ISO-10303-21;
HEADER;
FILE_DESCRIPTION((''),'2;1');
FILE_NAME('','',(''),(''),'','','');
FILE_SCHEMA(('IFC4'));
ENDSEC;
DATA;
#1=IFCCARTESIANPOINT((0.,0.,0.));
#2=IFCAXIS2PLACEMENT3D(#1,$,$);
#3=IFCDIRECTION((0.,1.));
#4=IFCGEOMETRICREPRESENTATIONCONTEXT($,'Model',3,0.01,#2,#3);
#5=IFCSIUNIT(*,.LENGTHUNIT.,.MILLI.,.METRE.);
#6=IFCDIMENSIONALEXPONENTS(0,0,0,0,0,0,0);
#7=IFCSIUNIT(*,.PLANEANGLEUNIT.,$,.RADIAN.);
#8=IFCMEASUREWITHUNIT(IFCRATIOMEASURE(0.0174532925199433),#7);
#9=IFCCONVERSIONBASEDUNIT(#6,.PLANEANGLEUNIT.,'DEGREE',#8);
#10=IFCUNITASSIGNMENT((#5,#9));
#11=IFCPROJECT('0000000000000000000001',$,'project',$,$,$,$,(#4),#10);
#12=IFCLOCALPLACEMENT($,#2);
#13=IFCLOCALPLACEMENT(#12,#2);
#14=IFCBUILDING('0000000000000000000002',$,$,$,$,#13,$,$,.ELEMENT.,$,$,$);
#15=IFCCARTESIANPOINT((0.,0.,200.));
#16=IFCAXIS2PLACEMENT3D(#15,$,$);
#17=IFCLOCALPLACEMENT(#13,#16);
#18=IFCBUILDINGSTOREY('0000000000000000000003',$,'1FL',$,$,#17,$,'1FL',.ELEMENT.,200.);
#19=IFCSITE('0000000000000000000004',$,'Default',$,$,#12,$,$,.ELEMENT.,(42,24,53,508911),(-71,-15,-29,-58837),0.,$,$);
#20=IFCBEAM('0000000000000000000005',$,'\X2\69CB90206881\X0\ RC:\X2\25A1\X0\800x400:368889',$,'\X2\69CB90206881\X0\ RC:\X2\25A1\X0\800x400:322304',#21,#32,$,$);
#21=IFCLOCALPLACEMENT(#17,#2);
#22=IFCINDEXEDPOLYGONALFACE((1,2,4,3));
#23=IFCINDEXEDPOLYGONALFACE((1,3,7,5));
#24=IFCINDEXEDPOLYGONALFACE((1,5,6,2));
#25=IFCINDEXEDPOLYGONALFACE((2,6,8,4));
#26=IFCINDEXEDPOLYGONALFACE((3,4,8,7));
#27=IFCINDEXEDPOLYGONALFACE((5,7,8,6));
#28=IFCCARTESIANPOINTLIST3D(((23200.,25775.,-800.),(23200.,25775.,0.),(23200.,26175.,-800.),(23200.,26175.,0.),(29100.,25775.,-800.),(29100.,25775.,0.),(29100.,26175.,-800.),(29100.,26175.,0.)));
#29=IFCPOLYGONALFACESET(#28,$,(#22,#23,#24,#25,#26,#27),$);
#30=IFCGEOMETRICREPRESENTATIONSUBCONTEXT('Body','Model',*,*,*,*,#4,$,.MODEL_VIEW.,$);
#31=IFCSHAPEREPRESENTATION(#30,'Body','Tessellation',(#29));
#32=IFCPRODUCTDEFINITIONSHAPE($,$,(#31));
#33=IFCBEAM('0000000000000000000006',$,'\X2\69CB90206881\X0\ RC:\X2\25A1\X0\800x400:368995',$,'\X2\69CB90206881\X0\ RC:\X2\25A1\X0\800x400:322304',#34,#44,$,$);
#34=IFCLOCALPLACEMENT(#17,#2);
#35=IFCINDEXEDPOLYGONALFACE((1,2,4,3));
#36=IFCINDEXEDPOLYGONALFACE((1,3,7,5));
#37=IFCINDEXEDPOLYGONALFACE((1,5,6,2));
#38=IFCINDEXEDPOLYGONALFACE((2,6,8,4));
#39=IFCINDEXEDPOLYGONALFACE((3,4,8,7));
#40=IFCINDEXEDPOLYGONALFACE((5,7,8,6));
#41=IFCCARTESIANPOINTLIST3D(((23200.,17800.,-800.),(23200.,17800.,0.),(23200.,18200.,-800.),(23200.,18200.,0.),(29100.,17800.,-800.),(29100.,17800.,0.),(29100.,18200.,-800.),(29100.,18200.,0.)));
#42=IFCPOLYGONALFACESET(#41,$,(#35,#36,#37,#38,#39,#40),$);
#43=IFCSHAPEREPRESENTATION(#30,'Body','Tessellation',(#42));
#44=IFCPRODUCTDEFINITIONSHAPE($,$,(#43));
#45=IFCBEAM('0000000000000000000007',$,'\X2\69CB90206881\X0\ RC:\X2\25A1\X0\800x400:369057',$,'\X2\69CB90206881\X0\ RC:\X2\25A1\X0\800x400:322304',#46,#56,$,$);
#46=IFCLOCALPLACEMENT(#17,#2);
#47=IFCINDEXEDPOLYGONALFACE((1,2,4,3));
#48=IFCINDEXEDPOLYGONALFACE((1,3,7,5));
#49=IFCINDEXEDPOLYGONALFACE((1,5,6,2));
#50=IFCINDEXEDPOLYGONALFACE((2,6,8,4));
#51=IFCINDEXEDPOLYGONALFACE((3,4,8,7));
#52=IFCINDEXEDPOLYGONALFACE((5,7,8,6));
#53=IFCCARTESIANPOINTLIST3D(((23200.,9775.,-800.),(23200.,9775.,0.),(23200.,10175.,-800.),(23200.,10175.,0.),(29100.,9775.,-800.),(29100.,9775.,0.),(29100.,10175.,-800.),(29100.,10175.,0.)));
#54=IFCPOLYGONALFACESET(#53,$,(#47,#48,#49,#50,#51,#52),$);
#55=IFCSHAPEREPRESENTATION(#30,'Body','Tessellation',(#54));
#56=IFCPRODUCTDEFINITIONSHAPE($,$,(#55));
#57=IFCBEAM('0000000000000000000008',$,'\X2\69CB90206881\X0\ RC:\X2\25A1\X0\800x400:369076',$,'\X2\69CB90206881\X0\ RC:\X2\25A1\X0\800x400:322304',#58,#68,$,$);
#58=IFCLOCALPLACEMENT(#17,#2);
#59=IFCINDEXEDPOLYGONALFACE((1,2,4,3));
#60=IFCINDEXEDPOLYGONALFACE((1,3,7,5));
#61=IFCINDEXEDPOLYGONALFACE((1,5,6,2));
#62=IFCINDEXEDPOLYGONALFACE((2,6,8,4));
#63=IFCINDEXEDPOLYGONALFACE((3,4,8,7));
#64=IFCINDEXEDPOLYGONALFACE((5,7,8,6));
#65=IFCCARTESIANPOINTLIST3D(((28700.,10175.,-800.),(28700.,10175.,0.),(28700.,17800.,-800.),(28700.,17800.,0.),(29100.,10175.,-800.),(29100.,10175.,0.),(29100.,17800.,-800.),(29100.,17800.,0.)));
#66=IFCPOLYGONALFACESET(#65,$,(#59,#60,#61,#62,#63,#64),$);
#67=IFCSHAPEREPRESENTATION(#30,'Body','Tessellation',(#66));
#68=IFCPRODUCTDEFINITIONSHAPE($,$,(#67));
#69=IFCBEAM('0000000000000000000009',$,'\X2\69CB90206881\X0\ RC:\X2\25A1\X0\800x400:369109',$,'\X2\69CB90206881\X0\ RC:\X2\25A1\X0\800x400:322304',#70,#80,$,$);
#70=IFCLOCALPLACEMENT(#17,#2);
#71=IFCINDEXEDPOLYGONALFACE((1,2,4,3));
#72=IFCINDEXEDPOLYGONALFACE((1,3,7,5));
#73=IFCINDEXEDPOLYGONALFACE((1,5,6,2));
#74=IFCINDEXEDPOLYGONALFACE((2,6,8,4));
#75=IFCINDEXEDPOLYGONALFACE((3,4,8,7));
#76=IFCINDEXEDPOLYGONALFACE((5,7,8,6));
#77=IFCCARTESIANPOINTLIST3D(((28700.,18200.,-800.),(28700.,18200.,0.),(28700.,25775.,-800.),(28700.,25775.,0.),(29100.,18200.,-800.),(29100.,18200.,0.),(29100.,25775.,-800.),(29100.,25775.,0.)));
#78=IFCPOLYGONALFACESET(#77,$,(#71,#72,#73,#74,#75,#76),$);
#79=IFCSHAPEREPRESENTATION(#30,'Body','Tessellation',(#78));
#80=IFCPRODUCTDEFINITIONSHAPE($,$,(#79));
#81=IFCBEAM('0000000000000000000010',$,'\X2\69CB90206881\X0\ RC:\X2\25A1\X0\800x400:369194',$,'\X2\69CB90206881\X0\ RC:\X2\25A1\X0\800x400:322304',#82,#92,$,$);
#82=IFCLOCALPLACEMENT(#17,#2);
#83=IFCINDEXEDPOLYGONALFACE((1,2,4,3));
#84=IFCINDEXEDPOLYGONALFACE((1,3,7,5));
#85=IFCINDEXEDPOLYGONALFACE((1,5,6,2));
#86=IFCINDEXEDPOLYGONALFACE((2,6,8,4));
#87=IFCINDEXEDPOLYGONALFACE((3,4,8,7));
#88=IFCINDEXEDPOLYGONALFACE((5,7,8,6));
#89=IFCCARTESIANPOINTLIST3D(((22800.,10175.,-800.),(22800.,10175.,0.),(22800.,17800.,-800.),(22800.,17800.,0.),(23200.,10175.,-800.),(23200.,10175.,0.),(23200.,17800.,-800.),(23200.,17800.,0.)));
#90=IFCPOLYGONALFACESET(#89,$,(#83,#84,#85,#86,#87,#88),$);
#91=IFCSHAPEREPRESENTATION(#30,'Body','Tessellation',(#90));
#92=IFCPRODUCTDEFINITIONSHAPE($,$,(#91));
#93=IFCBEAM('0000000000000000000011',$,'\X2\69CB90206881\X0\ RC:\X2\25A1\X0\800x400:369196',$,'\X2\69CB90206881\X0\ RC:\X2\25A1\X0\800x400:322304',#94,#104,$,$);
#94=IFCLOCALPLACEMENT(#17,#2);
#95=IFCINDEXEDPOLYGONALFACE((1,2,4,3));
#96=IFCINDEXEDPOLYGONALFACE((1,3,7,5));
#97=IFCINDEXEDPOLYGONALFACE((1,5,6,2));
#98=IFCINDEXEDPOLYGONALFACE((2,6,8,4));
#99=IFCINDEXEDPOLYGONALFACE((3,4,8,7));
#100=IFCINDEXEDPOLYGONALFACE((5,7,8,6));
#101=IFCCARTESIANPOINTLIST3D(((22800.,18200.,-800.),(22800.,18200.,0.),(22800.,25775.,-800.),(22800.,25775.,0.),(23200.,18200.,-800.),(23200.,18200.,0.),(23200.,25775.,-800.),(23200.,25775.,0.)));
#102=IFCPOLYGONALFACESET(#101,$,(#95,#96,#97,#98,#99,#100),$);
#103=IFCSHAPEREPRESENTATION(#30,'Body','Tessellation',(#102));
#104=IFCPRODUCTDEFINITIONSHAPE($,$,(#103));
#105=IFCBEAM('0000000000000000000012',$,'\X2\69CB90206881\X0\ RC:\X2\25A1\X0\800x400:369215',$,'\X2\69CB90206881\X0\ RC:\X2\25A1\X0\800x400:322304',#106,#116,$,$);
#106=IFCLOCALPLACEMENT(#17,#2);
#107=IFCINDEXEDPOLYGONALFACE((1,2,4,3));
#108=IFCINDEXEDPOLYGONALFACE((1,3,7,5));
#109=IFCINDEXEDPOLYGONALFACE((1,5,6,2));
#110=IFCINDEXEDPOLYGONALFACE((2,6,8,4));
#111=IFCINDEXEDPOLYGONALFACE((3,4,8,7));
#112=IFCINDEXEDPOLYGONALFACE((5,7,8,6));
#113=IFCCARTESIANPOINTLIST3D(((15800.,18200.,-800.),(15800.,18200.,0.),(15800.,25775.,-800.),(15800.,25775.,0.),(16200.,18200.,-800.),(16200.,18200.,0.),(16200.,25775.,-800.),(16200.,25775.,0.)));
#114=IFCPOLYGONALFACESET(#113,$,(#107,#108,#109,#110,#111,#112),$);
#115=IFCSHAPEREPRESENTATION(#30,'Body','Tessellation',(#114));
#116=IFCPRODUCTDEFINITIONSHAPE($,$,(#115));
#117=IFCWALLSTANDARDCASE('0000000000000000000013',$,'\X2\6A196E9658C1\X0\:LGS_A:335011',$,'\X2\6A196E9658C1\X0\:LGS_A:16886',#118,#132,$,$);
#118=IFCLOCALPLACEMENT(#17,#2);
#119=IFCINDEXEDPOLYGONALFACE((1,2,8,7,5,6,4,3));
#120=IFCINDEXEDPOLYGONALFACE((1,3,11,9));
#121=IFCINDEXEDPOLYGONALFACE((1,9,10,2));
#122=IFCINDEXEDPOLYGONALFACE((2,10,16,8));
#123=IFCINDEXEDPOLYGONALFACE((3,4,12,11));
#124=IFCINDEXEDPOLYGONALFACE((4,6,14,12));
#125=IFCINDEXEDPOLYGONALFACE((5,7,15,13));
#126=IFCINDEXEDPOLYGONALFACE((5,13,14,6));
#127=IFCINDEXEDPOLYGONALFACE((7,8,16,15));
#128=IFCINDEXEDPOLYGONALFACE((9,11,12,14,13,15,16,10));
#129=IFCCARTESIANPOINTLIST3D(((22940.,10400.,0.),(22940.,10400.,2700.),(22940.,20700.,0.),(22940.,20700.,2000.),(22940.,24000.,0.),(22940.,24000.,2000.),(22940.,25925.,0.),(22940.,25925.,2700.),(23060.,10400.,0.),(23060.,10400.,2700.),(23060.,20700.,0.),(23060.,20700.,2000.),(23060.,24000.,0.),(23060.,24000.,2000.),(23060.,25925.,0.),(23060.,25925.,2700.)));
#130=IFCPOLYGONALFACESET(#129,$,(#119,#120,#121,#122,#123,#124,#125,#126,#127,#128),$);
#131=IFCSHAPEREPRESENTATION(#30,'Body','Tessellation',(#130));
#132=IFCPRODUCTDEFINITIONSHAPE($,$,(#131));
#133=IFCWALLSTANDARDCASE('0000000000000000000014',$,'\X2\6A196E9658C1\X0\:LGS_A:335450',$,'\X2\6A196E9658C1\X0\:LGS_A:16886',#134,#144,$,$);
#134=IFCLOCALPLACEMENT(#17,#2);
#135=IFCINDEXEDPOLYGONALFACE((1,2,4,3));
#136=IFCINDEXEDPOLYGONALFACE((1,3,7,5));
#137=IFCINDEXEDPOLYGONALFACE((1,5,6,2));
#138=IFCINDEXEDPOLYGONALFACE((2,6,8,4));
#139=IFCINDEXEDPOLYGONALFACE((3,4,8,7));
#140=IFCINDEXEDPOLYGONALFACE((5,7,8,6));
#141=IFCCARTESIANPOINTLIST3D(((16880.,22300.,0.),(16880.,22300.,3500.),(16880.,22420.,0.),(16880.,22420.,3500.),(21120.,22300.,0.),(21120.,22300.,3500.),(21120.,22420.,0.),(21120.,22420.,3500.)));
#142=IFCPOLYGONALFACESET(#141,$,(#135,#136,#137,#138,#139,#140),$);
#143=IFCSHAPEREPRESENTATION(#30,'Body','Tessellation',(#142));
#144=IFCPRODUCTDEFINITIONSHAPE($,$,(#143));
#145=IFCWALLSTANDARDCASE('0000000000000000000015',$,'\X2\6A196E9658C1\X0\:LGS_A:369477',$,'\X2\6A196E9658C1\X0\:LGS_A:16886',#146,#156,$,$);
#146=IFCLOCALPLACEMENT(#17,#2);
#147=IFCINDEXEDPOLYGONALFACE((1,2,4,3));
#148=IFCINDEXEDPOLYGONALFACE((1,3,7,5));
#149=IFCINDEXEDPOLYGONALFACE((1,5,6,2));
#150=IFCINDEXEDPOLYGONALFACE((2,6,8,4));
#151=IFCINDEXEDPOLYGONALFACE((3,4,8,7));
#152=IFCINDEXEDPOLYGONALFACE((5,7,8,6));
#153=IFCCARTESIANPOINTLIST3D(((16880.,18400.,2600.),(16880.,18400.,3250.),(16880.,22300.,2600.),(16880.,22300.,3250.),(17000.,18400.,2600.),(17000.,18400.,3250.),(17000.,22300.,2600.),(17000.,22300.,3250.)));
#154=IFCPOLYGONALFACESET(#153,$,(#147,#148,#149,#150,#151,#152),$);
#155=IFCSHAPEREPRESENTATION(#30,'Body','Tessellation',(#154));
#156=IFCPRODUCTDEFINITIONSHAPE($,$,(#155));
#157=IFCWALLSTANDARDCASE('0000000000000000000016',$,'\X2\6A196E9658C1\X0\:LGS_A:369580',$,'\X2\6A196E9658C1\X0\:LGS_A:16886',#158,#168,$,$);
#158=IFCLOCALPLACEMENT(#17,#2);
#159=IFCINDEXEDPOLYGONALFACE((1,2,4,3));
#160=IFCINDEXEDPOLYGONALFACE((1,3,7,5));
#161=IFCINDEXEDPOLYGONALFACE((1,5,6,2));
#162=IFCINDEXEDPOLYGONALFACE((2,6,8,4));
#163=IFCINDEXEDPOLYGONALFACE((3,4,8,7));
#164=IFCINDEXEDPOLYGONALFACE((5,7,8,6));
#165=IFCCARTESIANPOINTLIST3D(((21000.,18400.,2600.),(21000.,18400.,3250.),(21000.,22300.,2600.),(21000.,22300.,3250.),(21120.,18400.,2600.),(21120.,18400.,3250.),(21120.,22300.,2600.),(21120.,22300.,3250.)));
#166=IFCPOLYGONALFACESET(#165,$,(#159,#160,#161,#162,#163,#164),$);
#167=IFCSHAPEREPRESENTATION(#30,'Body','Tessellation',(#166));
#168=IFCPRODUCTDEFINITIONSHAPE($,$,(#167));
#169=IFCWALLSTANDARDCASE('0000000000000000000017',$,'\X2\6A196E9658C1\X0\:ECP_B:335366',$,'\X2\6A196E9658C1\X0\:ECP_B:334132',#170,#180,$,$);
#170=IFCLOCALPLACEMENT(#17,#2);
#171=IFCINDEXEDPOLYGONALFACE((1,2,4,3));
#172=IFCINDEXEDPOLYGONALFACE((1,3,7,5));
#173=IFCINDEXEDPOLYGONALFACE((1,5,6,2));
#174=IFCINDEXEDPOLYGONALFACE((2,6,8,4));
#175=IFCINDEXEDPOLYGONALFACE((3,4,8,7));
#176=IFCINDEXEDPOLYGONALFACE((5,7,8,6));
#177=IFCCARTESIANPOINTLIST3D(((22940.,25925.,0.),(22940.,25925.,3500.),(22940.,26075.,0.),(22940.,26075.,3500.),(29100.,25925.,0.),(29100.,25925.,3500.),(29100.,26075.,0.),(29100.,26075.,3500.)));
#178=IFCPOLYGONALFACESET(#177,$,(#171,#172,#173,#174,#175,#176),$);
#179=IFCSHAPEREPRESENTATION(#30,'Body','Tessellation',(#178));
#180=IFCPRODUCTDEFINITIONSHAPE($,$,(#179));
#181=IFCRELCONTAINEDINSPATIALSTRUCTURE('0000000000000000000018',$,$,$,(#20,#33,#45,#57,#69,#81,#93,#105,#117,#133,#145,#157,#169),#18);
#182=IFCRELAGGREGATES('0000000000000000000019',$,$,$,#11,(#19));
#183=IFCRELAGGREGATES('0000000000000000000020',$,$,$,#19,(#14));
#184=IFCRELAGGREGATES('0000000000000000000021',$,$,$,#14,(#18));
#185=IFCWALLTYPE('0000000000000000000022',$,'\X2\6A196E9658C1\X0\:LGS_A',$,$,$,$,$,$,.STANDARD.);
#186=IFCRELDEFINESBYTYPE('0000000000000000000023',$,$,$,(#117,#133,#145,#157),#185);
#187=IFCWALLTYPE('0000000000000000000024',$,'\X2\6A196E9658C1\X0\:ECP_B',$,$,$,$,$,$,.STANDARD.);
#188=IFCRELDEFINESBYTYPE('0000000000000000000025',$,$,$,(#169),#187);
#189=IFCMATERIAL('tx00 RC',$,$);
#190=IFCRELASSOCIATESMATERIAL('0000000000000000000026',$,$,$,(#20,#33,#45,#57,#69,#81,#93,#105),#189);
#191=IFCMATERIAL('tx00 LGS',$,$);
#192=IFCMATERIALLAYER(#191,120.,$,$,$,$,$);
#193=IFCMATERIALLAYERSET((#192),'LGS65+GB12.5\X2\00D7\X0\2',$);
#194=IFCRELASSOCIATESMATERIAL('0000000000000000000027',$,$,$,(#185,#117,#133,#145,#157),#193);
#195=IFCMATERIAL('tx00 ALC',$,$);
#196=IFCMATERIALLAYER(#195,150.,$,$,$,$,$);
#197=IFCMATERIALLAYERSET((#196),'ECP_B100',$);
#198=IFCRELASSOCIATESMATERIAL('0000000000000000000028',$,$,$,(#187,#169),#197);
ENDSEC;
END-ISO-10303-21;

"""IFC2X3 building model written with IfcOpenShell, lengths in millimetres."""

from ifc_helpers import new_model, entity, si_unit, converted_unit, direction, frame, frame_2d, origin, origin_2d_with_axis, place, context, subcontext, project, spatial, polyline, rectangle, extrude, clip, bounded_halfspace, material, layer, layer_set, layer_usage, type_object, element, save


model = new_model("IFC2X3")

# Units and contexts
model_context = context("Model", 3, precision=0.01, world=origin(), true_north=direction((0.0, 1.0)))
body_context = subcontext(model_context, "Body", "Model", "MODEL_VIEW")
ifc_project = project(units=[si_unit("LENGTHUNIT", "METRE", prefix="MILLI"), converted_unit("PLANEANGLEUNIT", "DEGREE", entity("IfcRatioMeasure", 0.0174532925199433), si_unit("PLANEANGLEUNIT", "RADIAN"), dimensions=[0, 0, 0, 0, 0, 0, 0])], contexts=[model_context])

# Site, building, storey
site_placement = place(None, origin())
site = spatial("IfcSite", under=ifc_project, at=site_placement, Name="Default", CompositionType="ELEMENT", RefLatitude=(42, 24, 53, 508911), RefLongitude=(-71, -15, -29, -58837), RefElevation=0.0)
building_placement = place(site_placement, origin())
building = spatial("IfcBuilding", under=site, at=building_placement, CompositionType="ELEMENT")
storey_placement = place(building_placement, frame((0.0, 0.0, 200.0)))
storey = spatial("IfcBuildingStorey", under=building, at=storey_placement, Name="1FL", LongName="1FL", CompositionType="ELEMENT", Elevation=200.0)

# Beams
ifc_material_1 = material(Name="tx00 RC")
beam_1_placement = place(storey_placement, frame((23000.0, 25975.0, 0.0)))
element("IfcBeam", 1, at=beam_1_placement, inside=storey, material=ifc_material_1, Name="構造梁 RC:□800x400:368889", ObjectType="構造梁 RC:□800x400:322304", context=body_context, shape_type="SweptSolid", body=[
    extrude(rectangle(XDim=800.0, YDim=400.0, at=frame_2d((0.0, 0.0), x_axis=(1.0, 0.0))), frame((200.0, 0.0, -400.0), z_axis=(1.0, 0.0, 0.0), x_axis=(0.0, 0.0, -1.0)), (0.0, 0.0, 1.0), 5900.0),
])
for number, where, name in (
    (2, (23000.0, 18000.0, 0.0), "構造梁 RC:□800x400:368995"),
    (3, (23000.0, 9975.0, 0.0), "構造梁 RC:□800x400:369057"),
):
    element("IfcBeam", number, at=place(storey_placement, frame(where)), inside=storey, material=ifc_material_1, Name=name, ObjectType="構造梁 RC:□800x400:322304", context=body_context, shape_type="SweptSolid", body=[
        extrude(rectangle(XDim=800.0, YDim=400.0, at=frame_2d((0.0, 0.0), x_axis=(1.0, 0.0))), frame((200.0, 0.0, -400.0), z_axis=(1.0, 0.0, 0.0), x_axis=(0.0, 0.0, -1.0)), (0.0, 0.0, 1.0), 5900.0),
    ])
beam_2_placement = place(storey_placement, frame((28900.0, 9975.0, 0.0), z_axis=(0.0, 0.0, 1.0), x_axis=(0.0, 1.0, 0.0)))
element("IfcBeam", 4, at=beam_2_placement, inside=storey, material=ifc_material_1, Name="構造梁 RC:□800x400:369076", ObjectType="構造梁 RC:□800x400:322304", context=body_context, shape_type="SweptSolid", body=[
    extrude(rectangle(XDim=800.0, YDim=400.0, at=origin_2d_with_axis()), frame((200.0, 0.0, -400.0), z_axis=(1.0, 0.0, 0.0), x_axis=(0.0, 0.0, -1.0)), (0.0, 0.0, 1.0), 7625.0),
])
beam_3_placement = place(storey_placement, frame((28900.0, 18000.0, 0.0), z_axis=(0.0, 0.0, 1.0), x_axis=(0.0, 1.0, 0.0)))
element("IfcBeam", 5, at=beam_3_placement, inside=storey, material=ifc_material_1, Name="構造梁 RC:□800x400:369109", ObjectType="構造梁 RC:□800x400:322304", context=body_context, shape_type="SweptSolid", body=[
    extrude(rectangle(XDim=800.0, YDim=400.0, at=origin_2d_with_axis()), frame((200.0, 0.0, -400.0), z_axis=(1.0, 0.0, 0.0), x_axis=(0.0, 0.0, -1.0)), (0.0, 0.0, 1.0), 7575.0),
])
beam_4_placement = place(storey_placement, frame((23000.0, 9975.0, 0.0), z_axis=(0.0, 0.0, 1.0), x_axis=(0.0, 1.0, 0.0)))
element("IfcBeam", 6, at=beam_4_placement, inside=storey, material=ifc_material_1, Name="構造梁 RC:□800x400:369194", ObjectType="構造梁 RC:□800x400:322304", context=body_context, shape_type="SweptSolid", body=[
    extrude(rectangle(XDim=800.0, YDim=400.0, at=frame_2d((0.0, 0.0), x_axis=(1.0, 0.0))), frame((200.0, 0.0, -400.0), z_axis=(1.0, 0.0, 0.0), x_axis=(0.0, 0.0, -1.0)), (0.0, 0.0, 1.0), 7625.0),
])
beam_5_placement = place(storey_placement, frame((23000.0, 18000.0, 0.0), z_axis=(0.0, 0.0, 1.0), x_axis=(0.0, 1.0, 0.0)))
element("IfcBeam", 7, at=beam_5_placement, inside=storey, material=ifc_material_1, Name="構造梁 RC:□800x400:369196", ObjectType="構造梁 RC:□800x400:322304", context=body_context, shape_type="SweptSolid", body=[
    extrude(rectangle(XDim=800.0, YDim=400.0, at=frame_2d((0.0, 0.0), x_axis=(1.0, 0.0))), frame((200.0, 0.0, -400.0), z_axis=(1.0, 0.0, 0.0), x_axis=(0.0, 0.0, -1.0)), (0.0, 0.0, 1.0), 7575.0),
])
beam_6_placement = place(storey_placement, frame((16000.0, 18000.0, 0.0), z_axis=(0.0, 0.0, 1.0), x_axis=(0.0, 1.0, 0.0)))
element("IfcBeam", 8, at=beam_6_placement, inside=storey, material=ifc_material_1, Name="構造梁 RC:□800x400:369215", ObjectType="構造梁 RC:□800x400:322304", context=body_context, shape_type="SweptSolid", body=[
    extrude(rectangle(XDim=800.0, YDim=400.0, at=frame_2d((0.0, 0.0), x_axis=(1.0, 0.0))), frame((200.0, 0.0, -400.0), z_axis=(1.0, 0.0, 0.0), x_axis=(0.0, 0.0, -1.0)), (0.0, 0.0, 1.0), 7575.0),
])

# Shared definitions
ifc_material_2 = material(Name="tx00 ALC")

# Wall, opening
ifc_material_3 = material(Name="tx00 LGS")
ifc_layer_1 = layer(ifc_material_3, 120.0)
ifc_layer_set_1 = layer_set([ifc_layer_1], Name="LGS65+GB12.5×2")
ifc_layer_usage_1 = layer_usage(ifc_layer_set_1, "AXIS2", "NEGATIVE", 60.0)
wall_type_1 = type_object("IfcWallType", Name="標準壁:LGS_A", PredefinedType="STANDARD", material=ifc_layer_set_1)
wall_1_placement = place(storey_placement, frame((23000.0, 10400.0, 0.0), z_axis=(0.0, 0.0, 1.0), x_axis=(0.0, 1.0, 0.0)))
wall_1 = element("IfcWallStandardCase", 9, at=wall_1_placement, inside=storey, type_object=wall_type_1, material=ifc_layer_usage_1, Name="標準壁:LGS_A:335011", ObjectType="標準壁:LGS_A:16886", context=body_context, shape_type="SweptSolid", body=[
    extrude(rectangle(XDim=15525.0, YDim=120.0, at=frame_2d((7762.5, 0.0), x_axis=(-1.0, 0.0))), origin(), (0.0, 0.0, 1.0), 2700.0),
])
opening_1_placement = place(wall_1_placement, origin())
element("IfcOpeningElement", 10, at=opening_1_placement, cuts=wall_1, ObjectType="Opening", context=body_context, shape_type="SweptSolid", body=[
    extrude(rectangle(XDim=2000.0, YDim=3300.0, at=origin_2d_with_axis()), frame((11950.0, -60.0, 1000.0), z_axis=(0.0, 1.0, 0.0), x_axis=(0.0, 0.0, -1.0)), (0.0, 0.0, 1.0), 120.0),
])

# Walls
ifc_layer_usage_2 = layer_usage(ifc_layer_set_1, "AXIS2", "NEGATIVE", 60.0)
wall_2_placement = place(storey_placement, frame((16880.0, 22360.0, 0.0)))
element("IfcWallStandardCase", 11, at=wall_2_placement, inside=storey, type_object=wall_type_1, material=ifc_layer_usage_2, Name="標準壁:LGS_A:335450", ObjectType="標準壁:LGS_A:16886", context=body_context, shape_type="SweptSolid", body=[
    extrude(rectangle(XDim=4240.0, YDim=120.0, at=frame_2d((2120.0, 0.0), x_axis=(-1.0, 0.0))), origin(), (0.0, 0.0, 1.0), 3500.0),
])
ifc_layer_usage_3 = layer_usage(ifc_layer_set_1, "AXIS2", "NEGATIVE", 60.0)
wall_3_placement = place(storey_placement, frame((16940.0, 22300.0, 2600.0), z_axis=(0.0, 0.0, 1.0), x_axis=(0.0, -1.0, 0.0)))
element("IfcWallStandardCase", 12, at=wall_3_placement, inside=storey, type_object=wall_type_1, material=ifc_layer_usage_3, Name="標準壁:LGS_A:369477", ObjectType="標準壁:LGS_A:16886", context=body_context, shape_type="Clipping", body=[
    clip(extrude(rectangle(XDim=3900.0, YDim=120.0, at=frame_2d((1950.0, 0.0), x_axis=(-1.0, 0.0))), origin(), (0.0, 0.0, 1.0), 650.0), bounded_halfspace(frame((0.0, -60.0, 650.0), z_axis=(0.0, 0.0, -1.0), x_axis=(1.0, 0.0, 0.0)), True, frame((0.0, -60.0, 650.0)), polyline([(0.0, 0.0), (3900.0, 0.0), (3900.0, 120.0), (0.0, 120.0), (0.0, 0.0)]))),
])
ifc_layer_usage_4 = layer_usage(ifc_layer_set_1, "AXIS2", "NEGATIVE", 60.0)
wall_4_placement = place(storey_placement, frame((21060.0, 22300.0, 2600.0), z_axis=(0.0, 0.0, 1.0), x_axis=(0.0, -1.0, 0.0)))
element("IfcWallStandardCase", 13, at=wall_4_placement, inside=storey, type_object=wall_type_1, material=ifc_layer_usage_4, Name="標準壁:LGS_A:369580", ObjectType="標準壁:LGS_A:16886", context=body_context, shape_type="Clipping", body=[
    clip(extrude(rectangle(XDim=3900.0, YDim=120.0, at=frame_2d((1950.0, 0.0), x_axis=(-1.0, 0.0))), origin(), (0.0, 0.0, 1.0), 650.0), bounded_halfspace(frame((0.0, -60.0, 650.0), z_axis=(0.0, 0.0, -1.0), x_axis=(1.0, 0.0, 0.0)), True, frame((0.0, -60.0, 650.0)), polyline([(0.0, 0.0), (3900.0, 0.0), (3900.0, 120.0), (0.0, 120.0), (0.0, 0.0)]))),
])
ifc_layer_2 = layer(ifc_material_2, 150.0)
ifc_layer_set_2 = layer_set([ifc_layer_2], Name="ECP_B100")
ifc_layer_usage_5 = layer_usage(ifc_layer_set_2, "AXIS2", "NEGATIVE", 75.0)
wall_type_2 = type_object("IfcWallType", Name="標準壁:ECP_B", PredefinedType="STANDARD", material=ifc_layer_set_2)
wall_5_placement = place(storey_placement, frame((22940.0, 26000.0, 0.0)))
element("IfcWallStandardCase", 14, at=wall_5_placement, inside=storey, type_object=wall_type_2, material=ifc_layer_usage_5, Name="標準壁:ECP_B:335366", ObjectType="標準壁:ECP_B:334132", context=body_context, shape_type="SweptSolid", body=[
    extrude(rectangle(XDim=6160.0, YDim=150.0, at=frame_2d((3080.0, 0.0), x_axis=(-1.0, 0.0))), origin(), (0.0, 0.0, 1.0), 3500.0),
])

save(model, "model.ifc")
